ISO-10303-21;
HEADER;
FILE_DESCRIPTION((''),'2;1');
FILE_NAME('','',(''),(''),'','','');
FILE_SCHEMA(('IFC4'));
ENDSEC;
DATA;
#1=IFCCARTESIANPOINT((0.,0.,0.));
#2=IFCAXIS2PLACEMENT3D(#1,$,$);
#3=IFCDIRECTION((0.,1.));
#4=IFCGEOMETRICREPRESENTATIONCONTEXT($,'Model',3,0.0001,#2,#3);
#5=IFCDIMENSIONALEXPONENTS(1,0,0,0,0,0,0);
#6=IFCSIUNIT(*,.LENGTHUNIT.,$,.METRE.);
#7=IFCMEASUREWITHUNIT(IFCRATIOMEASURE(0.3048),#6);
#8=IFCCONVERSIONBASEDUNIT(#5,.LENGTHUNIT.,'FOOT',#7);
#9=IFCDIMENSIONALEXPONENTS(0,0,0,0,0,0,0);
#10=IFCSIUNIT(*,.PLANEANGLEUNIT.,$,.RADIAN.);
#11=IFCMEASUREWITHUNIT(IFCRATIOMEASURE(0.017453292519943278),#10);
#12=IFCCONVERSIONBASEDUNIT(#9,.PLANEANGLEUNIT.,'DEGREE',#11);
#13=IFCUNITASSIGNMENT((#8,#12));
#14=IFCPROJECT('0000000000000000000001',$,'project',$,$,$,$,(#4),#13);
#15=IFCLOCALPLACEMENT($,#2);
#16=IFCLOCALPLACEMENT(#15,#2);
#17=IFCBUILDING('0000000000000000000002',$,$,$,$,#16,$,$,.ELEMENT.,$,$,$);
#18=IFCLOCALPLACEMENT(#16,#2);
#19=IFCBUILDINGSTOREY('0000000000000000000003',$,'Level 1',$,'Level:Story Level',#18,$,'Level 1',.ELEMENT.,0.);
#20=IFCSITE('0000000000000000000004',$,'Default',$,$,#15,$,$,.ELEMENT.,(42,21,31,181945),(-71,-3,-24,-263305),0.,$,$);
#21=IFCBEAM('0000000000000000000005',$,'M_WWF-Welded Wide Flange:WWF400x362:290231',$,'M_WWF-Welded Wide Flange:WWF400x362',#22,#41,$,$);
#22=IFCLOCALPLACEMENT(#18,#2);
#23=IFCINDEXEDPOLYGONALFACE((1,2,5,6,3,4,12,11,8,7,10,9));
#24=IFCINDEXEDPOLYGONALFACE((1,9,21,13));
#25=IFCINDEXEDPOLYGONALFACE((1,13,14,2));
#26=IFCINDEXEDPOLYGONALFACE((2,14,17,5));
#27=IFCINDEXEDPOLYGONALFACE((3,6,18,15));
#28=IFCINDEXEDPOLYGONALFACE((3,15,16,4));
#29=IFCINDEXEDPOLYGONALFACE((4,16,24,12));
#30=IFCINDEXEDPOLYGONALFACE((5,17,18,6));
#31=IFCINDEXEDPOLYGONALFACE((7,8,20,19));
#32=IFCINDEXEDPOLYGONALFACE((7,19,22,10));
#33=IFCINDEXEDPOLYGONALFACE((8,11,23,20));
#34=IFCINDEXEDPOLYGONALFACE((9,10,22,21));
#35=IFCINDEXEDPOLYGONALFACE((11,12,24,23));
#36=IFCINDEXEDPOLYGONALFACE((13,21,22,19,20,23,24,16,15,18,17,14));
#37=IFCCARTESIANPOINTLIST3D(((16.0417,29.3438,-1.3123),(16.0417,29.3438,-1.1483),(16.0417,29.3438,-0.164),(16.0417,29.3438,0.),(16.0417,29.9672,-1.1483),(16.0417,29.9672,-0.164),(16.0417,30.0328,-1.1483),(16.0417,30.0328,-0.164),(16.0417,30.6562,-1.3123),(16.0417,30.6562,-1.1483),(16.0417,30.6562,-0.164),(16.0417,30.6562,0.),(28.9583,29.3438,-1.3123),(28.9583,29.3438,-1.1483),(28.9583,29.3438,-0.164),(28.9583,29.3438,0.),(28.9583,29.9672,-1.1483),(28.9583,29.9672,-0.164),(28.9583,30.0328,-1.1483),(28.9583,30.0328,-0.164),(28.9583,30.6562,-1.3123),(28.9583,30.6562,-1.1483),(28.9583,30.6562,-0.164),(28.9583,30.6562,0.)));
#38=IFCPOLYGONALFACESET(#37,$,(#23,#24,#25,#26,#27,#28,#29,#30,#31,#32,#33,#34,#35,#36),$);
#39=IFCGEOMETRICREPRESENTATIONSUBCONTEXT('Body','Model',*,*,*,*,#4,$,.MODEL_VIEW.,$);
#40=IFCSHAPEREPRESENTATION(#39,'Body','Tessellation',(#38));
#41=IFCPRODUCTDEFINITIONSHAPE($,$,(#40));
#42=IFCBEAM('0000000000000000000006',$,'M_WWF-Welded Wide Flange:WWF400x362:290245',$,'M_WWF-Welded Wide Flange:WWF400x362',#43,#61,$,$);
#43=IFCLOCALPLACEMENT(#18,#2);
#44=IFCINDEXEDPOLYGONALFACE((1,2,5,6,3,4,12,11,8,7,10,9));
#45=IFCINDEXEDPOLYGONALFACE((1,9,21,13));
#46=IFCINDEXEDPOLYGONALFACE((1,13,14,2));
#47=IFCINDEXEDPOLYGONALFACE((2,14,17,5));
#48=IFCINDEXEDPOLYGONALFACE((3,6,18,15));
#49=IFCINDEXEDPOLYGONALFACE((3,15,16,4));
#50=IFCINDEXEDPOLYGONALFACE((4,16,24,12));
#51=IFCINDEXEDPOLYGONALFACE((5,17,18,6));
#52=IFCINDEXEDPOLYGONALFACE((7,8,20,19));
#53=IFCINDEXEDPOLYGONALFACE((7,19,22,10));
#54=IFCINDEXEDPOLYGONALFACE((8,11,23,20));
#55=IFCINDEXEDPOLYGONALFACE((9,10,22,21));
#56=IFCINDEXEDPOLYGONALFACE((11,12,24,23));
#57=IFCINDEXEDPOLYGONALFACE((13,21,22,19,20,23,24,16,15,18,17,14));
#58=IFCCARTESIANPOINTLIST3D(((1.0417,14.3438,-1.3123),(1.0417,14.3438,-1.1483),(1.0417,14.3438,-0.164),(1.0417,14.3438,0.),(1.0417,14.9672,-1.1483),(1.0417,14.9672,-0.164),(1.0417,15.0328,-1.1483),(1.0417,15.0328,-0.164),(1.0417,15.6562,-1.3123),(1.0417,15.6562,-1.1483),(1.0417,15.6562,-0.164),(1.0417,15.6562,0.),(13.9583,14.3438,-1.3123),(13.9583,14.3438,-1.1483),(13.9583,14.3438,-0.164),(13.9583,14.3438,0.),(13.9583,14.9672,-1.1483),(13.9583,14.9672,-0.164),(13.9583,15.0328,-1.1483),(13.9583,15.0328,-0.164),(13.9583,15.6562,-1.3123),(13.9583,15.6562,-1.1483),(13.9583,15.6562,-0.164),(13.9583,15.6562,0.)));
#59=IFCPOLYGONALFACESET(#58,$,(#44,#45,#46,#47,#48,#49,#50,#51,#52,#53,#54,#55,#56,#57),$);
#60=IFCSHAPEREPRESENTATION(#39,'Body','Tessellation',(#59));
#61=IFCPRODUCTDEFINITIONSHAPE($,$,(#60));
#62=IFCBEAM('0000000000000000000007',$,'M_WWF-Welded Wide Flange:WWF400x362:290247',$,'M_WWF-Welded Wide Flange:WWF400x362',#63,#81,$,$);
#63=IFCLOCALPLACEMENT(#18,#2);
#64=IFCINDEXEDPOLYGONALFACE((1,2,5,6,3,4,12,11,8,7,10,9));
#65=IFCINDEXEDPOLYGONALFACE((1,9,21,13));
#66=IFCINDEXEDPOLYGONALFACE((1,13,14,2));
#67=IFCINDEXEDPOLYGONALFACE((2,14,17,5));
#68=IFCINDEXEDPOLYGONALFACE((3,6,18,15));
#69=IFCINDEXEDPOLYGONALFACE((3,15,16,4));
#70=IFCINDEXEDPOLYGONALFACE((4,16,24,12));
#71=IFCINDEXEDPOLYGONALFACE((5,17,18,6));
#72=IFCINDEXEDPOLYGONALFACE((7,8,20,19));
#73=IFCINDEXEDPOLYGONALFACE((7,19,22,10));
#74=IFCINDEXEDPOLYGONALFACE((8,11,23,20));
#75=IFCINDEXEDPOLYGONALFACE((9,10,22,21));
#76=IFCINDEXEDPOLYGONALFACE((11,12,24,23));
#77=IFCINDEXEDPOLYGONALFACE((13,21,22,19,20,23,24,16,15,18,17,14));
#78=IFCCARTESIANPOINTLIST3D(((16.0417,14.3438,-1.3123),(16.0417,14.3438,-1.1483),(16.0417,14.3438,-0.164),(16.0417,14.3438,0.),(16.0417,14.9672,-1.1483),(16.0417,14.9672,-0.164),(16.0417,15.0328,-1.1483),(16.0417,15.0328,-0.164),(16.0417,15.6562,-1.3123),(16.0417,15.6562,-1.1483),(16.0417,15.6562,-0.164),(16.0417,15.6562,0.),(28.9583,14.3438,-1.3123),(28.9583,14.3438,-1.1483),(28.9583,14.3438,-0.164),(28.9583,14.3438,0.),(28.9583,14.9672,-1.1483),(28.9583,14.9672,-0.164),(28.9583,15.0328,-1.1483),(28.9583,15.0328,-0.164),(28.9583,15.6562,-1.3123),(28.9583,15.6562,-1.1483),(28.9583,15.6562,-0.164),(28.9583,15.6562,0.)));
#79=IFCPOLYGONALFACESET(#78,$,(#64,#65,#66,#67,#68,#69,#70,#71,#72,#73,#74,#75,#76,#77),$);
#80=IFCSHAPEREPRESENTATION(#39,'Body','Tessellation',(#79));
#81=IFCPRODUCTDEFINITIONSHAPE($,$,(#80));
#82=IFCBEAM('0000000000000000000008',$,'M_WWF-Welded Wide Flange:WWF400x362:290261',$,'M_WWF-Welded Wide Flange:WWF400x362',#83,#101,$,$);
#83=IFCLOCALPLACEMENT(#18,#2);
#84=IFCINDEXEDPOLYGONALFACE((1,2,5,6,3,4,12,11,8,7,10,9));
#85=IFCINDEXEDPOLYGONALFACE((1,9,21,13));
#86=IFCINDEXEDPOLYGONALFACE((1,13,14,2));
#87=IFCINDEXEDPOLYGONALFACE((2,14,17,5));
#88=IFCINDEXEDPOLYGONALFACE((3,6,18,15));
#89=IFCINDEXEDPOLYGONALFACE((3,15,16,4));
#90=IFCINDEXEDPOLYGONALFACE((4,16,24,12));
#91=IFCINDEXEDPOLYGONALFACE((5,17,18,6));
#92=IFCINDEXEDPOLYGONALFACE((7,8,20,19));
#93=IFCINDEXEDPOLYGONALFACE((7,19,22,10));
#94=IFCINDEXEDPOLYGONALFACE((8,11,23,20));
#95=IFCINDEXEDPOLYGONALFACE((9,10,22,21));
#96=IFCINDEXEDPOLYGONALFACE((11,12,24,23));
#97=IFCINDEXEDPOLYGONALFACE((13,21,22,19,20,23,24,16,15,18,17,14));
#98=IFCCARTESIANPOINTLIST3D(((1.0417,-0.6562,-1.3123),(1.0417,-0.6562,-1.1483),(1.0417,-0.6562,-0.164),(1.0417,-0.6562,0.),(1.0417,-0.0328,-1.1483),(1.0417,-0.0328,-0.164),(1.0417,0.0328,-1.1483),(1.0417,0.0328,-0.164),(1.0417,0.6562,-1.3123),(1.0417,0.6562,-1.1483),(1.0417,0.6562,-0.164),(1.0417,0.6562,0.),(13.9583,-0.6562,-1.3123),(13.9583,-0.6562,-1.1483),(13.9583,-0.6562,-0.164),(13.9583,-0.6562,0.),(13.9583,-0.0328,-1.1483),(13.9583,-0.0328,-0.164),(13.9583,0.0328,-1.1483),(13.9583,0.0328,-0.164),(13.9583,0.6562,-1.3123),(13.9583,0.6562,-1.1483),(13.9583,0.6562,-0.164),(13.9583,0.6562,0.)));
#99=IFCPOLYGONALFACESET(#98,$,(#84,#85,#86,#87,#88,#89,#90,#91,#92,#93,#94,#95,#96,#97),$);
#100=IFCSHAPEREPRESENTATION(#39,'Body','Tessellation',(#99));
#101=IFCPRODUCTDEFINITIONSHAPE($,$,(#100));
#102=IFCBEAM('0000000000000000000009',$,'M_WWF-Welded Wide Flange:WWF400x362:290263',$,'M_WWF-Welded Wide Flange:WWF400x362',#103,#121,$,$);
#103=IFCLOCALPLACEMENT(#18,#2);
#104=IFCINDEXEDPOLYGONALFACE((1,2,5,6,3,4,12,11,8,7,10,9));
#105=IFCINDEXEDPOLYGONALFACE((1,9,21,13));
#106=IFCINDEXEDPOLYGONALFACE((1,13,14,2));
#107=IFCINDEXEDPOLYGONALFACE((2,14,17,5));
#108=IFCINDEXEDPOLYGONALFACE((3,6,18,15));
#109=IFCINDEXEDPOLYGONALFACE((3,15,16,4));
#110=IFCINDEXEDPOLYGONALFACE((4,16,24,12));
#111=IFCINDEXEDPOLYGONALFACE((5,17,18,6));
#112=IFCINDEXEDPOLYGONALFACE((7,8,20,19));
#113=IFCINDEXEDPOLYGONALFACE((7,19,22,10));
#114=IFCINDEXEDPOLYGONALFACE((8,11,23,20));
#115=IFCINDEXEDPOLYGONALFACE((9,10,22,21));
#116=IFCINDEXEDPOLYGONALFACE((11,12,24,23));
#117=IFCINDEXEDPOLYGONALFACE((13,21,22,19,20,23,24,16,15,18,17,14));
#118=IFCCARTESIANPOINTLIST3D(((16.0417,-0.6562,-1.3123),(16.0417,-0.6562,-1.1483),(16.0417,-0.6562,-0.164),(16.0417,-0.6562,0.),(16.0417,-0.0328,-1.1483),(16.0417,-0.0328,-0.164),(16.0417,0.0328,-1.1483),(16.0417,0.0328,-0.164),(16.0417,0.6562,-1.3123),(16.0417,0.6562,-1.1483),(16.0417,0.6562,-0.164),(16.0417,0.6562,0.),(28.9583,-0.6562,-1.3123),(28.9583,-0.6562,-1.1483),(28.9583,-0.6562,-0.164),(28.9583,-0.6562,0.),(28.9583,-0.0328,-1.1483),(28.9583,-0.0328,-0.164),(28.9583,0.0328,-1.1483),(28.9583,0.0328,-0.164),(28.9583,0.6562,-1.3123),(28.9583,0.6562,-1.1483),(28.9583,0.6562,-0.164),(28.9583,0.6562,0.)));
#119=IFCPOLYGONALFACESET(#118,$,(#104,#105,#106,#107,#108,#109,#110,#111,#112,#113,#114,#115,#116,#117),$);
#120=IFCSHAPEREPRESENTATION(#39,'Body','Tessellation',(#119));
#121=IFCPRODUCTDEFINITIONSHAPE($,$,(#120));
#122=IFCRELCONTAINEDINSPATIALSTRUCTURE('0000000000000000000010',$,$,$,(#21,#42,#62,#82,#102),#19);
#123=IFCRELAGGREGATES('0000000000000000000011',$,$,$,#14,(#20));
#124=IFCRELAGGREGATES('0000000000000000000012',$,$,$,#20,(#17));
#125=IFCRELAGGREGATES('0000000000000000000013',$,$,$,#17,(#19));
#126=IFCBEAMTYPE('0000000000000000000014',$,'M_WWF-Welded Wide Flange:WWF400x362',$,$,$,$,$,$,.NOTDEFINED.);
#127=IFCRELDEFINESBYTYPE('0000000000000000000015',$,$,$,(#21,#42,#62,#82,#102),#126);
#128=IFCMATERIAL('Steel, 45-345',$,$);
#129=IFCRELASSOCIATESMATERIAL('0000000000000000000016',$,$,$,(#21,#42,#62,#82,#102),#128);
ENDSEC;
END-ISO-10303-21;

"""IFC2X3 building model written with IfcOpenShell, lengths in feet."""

from ifc_helpers import new_model, entity, si_unit, converted_unit, direction, frame, frame_2d, origin, place, context, subcontext, project, spatial, i_section, extrude, material, type_object, element, save


model = new_model("IFC2X3")

# Units and contexts
model_context = context("Model", 3, precision=0.0001, world=origin(), true_north=direction((0.0, 1.0)))
body_context = subcontext(model_context, "Body", "Model", "MODEL_VIEW")
ifc_project = project(units=[converted_unit("LENGTHUNIT", "FOOT", entity("IfcRatioMeasure", 0.3048), si_unit("LENGTHUNIT", "METRE"), dimensions=[1, 0, 0, 0, 0, 0, 0]), converted_unit("PLANEANGLEUNIT", "DEGREE", entity("IfcRatioMeasure", 0.017453292519943278), si_unit("PLANEANGLEUNIT", "RADIAN"), dimensions=[0, 0, 0, 0, 0, 0, 0])], contexts=[model_context])

# Site, building, storey
site_placement = place(None, origin())
site = spatial("IfcSite", under=ifc_project, at=site_placement, Name="Default", CompositionType="ELEMENT", RefLatitude=(42, 21, 31, 181945), RefLongitude=(-71, -3, -24, -263305), RefElevation=0.0)
building_placement = place(site_placement, origin())
building = spatial("IfcBuilding", under=site, at=building_placement, CompositionType="ELEMENT")
storey_placement = place(building_placement, origin())
storey = spatial("IfcBuildingStorey", under=building, at=storey_placement, Name="Level 1", ObjectType="Level:Story Level", LongName="Level 1", CompositionType="ELEMENT", Elevation=0.0)

# Shared definitions
ifc_material = material(Name="Steel, 45-345")

# Beams
beam_type = type_object("IfcBeamType", Name="M_WWF-Welded Wide Flange:WWF400x362", PredefinedType="NOTDEFINED")
beam_1_placement = place(storey_placement, frame((15.0, 30.0, 0.0)))
element("IfcBeam", 1, at=beam_1_placement, inside=storey, type_object=beam_type, material=ifc_material, Name="M_WWF-Welded Wide Flange:WWF400x362:290231", ObjectType="M_WWF-Welded Wide Flange:WWF400x362", context=body_context, shape_type="SweptSolid", body=[
    extrude(i_section(OverallWidth=1.3123, OverallDepth=1.3123, WebThickness=0.0656, FlangeThickness=0.164, at=frame_2d((0.0, 0.0), x_axis=(0.0, 1.0))), frame((1.0417, 0.0, -0.6562), z_axis=(1.0, 0.0, 0.0), x_axis=(0.0, 0.0, -1.0)), (0.0, 0.0, 1.0), 12.9167),
])
beam_2_placement = place(storey_placement, frame((0.0, 15.0, 0.0)))
element("IfcBeam", 2, at=beam_2_placement, inside=storey, type_object=beam_type, material=ifc_material, Name="M_WWF-Welded Wide Flange:WWF400x362:290245", ObjectType="M_WWF-Welded Wide Flange:WWF400x362", context=body_context, shape_type="SweptSolid", body=[
    extrude(i_section(OverallWidth=1.3123, OverallDepth=1.3123, WebThickness=0.0656, FlangeThickness=0.164, at=frame_2d((0.0, 0.0), x_axis=(0.0, 1.0))), frame((1.0417, 0.0, -0.6562), z_axis=(1.0, 0.0, 0.0), x_axis=(0.0, 0.0, -1.0)), (0.0, 0.0, 1.0), 12.9167),
])
beam_3_placement = place(storey_placement, frame((15.0, 15.0, 0.0)))
element("IfcBeam", 3, at=beam_3_placement, inside=storey, type_object=beam_type, material=ifc_material, Name="M_WWF-Welded Wide Flange:WWF400x362:290247", ObjectType="M_WWF-Welded Wide Flange:WWF400x362", context=body_context, shape_type="SweptSolid", body=[
    extrude(i_section(OverallWidth=1.3123, OverallDepth=1.3123, WebThickness=0.0656, FlangeThickness=0.164, at=frame_2d((0.0, 0.0), x_axis=(0.0, 1.0))), frame((1.0417, 0.0, -0.6562), z_axis=(1.0, 0.0, 0.0), x_axis=(0.0, 0.0, -1.0)), (0.0, 0.0, 1.0), 12.9167),
])
beam_4_placement = place(storey_placement, origin())
element("IfcBeam", 4, at=beam_4_placement, inside=storey, type_object=beam_type, material=ifc_material, Name="M_WWF-Welded Wide Flange:WWF400x362:290261", ObjectType="M_WWF-Welded Wide Flange:WWF400x362", context=body_context, shape_type="SweptSolid", body=[
    extrude(i_section(OverallWidth=1.3123, OverallDepth=1.3123, WebThickness=0.0656, FlangeThickness=0.164, at=frame_2d((0.0, 0.0), x_axis=(0.0, 1.0))), frame((1.0417, 0.0, -0.6562), z_axis=(1.0, 0.0, 0.0), x_axis=(0.0, 0.0, -1.0)), (0.0, 0.0, 1.0), 12.9167),
])
beam_5_placement = place(storey_placement, frame((15.0, 0.0, 0.0)))
element("IfcBeam", 5, at=beam_5_placement, inside=storey, type_object=beam_type, material=ifc_material, Name="M_WWF-Welded Wide Flange:WWF400x362:290263", ObjectType="M_WWF-Welded Wide Flange:WWF400x362", context=body_context, shape_type="SweptSolid", body=[
    extrude(i_section(OverallWidth=1.3123, OverallDepth=1.3123, WebThickness=0.0656, FlangeThickness=0.164, at=frame_2d((0.0, 0.0), x_axis=(0.0, 1.0))), frame((1.0417, 0.0, -0.6562), z_axis=(1.0, 0.0, 0.0), x_axis=(0.0, 0.0, -1.0)), (0.0, 0.0, 1.0), 12.9167),
])

save(model, "model.ifc")
